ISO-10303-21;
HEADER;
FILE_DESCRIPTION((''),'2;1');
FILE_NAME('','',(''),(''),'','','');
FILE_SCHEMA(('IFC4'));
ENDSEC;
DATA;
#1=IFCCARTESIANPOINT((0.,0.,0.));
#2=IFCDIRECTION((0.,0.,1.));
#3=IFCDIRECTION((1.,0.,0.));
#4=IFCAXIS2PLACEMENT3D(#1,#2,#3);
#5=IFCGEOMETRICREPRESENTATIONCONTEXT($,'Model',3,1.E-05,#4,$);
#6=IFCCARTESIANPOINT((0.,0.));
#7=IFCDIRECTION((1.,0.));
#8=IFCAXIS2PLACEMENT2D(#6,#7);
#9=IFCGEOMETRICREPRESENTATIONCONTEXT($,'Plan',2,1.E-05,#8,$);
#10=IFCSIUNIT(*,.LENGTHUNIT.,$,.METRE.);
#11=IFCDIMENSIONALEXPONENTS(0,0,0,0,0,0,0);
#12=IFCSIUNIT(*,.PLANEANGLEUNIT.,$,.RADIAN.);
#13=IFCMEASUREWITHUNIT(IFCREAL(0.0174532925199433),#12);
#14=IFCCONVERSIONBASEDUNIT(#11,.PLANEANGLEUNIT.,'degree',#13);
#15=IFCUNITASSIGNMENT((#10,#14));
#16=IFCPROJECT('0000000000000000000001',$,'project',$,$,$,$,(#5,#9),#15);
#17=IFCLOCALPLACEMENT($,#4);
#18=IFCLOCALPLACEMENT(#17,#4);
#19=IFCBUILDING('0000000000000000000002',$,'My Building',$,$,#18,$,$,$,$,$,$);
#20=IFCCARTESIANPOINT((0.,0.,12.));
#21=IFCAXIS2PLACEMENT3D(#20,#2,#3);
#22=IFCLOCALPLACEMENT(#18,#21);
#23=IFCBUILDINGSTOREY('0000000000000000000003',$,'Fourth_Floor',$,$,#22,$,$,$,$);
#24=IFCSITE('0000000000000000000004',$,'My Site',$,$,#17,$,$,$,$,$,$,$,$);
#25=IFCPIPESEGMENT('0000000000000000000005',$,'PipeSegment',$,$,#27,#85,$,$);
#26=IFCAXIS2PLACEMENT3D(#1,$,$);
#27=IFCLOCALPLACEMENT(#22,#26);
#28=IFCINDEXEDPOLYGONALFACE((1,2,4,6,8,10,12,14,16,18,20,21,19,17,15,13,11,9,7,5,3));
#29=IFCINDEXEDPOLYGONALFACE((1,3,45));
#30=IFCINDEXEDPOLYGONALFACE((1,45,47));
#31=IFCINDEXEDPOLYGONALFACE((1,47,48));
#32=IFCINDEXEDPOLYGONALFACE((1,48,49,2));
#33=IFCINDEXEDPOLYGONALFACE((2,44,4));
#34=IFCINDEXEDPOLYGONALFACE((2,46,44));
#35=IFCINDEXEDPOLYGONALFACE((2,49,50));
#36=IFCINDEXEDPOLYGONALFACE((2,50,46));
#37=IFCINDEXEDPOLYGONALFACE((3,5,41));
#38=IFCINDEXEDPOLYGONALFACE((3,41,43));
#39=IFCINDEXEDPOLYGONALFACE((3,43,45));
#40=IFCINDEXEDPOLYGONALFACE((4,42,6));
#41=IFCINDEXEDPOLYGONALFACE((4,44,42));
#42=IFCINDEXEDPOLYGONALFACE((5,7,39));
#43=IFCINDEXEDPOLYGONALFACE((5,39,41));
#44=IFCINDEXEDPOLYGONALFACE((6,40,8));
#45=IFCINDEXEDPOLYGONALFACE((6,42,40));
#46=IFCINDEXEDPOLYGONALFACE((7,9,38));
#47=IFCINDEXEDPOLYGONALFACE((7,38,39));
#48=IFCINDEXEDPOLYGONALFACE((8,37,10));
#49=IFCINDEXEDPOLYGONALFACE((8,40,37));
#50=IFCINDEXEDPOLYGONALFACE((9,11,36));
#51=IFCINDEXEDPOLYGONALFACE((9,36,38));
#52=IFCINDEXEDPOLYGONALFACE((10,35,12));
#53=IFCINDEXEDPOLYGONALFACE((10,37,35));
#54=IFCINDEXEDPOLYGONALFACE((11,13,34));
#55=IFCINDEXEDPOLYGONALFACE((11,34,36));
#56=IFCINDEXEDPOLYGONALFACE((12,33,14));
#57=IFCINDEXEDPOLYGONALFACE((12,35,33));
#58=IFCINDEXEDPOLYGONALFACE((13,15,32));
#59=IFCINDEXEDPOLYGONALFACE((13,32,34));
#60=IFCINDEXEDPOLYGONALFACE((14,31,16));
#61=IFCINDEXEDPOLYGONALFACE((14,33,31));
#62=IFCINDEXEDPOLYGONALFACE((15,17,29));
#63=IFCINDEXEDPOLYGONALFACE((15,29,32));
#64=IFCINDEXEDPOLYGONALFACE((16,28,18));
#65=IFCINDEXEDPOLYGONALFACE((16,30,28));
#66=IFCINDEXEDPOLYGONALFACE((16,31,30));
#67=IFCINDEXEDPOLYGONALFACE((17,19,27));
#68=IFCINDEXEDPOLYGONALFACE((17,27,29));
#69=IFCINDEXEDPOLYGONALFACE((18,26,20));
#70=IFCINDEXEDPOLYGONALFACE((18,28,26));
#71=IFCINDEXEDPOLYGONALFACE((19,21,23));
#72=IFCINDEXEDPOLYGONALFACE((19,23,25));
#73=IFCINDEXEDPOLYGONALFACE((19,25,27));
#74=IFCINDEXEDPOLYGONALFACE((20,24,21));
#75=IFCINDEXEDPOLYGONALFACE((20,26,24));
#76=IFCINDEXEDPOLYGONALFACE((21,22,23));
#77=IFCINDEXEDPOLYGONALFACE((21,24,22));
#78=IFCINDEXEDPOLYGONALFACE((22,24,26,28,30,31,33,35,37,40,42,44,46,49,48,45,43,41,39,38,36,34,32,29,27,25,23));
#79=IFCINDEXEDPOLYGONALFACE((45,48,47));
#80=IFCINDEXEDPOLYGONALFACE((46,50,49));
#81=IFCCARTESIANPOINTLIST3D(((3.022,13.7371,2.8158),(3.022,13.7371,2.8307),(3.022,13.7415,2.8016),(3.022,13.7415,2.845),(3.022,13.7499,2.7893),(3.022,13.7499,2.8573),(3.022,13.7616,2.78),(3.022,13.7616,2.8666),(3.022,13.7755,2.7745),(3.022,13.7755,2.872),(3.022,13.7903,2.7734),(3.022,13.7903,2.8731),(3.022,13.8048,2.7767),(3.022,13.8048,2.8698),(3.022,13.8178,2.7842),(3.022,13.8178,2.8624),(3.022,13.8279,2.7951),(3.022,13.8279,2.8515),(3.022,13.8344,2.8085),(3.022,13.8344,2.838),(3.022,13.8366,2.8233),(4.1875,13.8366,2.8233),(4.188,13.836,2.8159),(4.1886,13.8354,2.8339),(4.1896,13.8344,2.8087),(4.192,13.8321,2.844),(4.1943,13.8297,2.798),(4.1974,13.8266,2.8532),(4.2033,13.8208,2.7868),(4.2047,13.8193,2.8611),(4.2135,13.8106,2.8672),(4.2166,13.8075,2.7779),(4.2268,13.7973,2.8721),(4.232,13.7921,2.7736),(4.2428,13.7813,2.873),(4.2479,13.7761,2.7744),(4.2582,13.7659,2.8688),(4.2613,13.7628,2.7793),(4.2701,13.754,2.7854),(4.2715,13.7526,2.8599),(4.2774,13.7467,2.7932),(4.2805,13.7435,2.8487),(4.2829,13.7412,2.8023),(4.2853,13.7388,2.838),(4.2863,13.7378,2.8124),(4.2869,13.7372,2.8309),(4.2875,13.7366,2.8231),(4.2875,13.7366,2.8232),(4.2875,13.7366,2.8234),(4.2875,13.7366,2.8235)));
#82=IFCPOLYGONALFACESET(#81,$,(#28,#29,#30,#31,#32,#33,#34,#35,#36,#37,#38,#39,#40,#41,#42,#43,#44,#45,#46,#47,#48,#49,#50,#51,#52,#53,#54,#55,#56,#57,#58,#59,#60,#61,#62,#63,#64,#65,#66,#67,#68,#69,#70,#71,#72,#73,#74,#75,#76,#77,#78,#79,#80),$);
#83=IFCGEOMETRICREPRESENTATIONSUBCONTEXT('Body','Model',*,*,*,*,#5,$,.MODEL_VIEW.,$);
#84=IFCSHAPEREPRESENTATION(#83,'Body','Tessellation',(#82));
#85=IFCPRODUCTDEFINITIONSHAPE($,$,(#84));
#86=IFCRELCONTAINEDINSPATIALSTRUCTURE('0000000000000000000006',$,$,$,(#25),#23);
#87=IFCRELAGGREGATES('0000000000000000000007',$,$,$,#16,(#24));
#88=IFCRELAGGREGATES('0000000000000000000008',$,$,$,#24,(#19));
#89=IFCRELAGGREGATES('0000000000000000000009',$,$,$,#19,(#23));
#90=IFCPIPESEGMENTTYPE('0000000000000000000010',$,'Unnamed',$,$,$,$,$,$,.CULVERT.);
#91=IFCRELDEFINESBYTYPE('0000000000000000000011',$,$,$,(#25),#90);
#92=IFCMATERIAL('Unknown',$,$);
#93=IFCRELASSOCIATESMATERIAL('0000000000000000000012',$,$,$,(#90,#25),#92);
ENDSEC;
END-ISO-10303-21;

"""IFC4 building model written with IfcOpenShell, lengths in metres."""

from ifc_helpers import new_model, entity, si_unit, converted_unit, frame, origin_with_axes, origin_2d_with_axis, place, context, subcontext, project, spatial, circle, extrude, clip, halfspace, material, material_profile, profile_set, profile_usage, type_object, element, save


model = new_model("IFC4")

# Units and contexts
model_context = context("Model", 3, precision=1e-05, world=origin_with_axes())
plan_context = context("Plan", 2, precision=1e-05, world=origin_2d_with_axis())
body_context_1 = subcontext(model_context, "Body", "Model", "MODEL_VIEW")
ifc_project = project(units=[si_unit("LENGTHUNIT", "METRE"), converted_unit("PLANEANGLEUNIT", "degree", entity("IfcReal", 0.0174532925199433), si_unit("PLANEANGLEUNIT", "RADIAN"), dimensions=[0, 0, 0, 0, 0, 0, 0])], contexts=[model_context, plan_context])

# Site, building, storey
site_placement = place(None, origin_with_axes())
site = spatial("IfcSite", under=ifc_project, at=site_placement, Name="My Site")
building_placement = place(site_placement, origin_with_axes())
building = spatial("IfcBuilding", under=site, at=building_placement, Name="My Building")
storey_placement = place(building_placement, frame((0.0, 0.0, 12.0), z_axis=(0.0, 0.0, 1.0), x_axis=(1.0, 0.0, 0.0)))
storey = spatial("IfcBuildingStorey", under=building, at=storey_placement, Name="Fourth_Floor")

# Shared definitions
ifc_material = material(Name="Unknown")

# Pipe segment
ifc_material_profile_1 = material_profile(ifc_material, circle(Radius=0.05))
ifc_profile_set_1 = profile_set([ifc_material_profile_1])
pipe_segment_type = type_object("IfcPipeSegmentType", Name="Unnamed", PredefinedType="CULVERT", material=ifc_profile_set_1)
ifc_profile_usage_1 = profile_usage(ifc_profile_set_1, cardinal=5)
pipe_segment_1_placement = place(storey_placement, frame((3.022, 13.7866, 2.8233), z_axis=(1.0, 0.0, 0.0), x_axis=(0.0, 1.0, 0.0)))
element("IfcPipeSegment", 1, at=pipe_segment_1_placement, inside=storey, type_object=pipe_segment_type, material=ifc_profile_usage_1, Name="PipeSegment", context=body_context_1, shape_type="Clipping", body=[
    clip(extrude(circle(Radius=0.05), origin_with_axes(), (0.0, 0.0, 1.0), 1.2655), halfspace(frame((-0.05, -3.0, 1.2655), z_axis=(0.707107, 0.0, 0.707107), x_axis=(0.0, -1.0, 0.0)), False)),
])

save(model, "model.ifc")
